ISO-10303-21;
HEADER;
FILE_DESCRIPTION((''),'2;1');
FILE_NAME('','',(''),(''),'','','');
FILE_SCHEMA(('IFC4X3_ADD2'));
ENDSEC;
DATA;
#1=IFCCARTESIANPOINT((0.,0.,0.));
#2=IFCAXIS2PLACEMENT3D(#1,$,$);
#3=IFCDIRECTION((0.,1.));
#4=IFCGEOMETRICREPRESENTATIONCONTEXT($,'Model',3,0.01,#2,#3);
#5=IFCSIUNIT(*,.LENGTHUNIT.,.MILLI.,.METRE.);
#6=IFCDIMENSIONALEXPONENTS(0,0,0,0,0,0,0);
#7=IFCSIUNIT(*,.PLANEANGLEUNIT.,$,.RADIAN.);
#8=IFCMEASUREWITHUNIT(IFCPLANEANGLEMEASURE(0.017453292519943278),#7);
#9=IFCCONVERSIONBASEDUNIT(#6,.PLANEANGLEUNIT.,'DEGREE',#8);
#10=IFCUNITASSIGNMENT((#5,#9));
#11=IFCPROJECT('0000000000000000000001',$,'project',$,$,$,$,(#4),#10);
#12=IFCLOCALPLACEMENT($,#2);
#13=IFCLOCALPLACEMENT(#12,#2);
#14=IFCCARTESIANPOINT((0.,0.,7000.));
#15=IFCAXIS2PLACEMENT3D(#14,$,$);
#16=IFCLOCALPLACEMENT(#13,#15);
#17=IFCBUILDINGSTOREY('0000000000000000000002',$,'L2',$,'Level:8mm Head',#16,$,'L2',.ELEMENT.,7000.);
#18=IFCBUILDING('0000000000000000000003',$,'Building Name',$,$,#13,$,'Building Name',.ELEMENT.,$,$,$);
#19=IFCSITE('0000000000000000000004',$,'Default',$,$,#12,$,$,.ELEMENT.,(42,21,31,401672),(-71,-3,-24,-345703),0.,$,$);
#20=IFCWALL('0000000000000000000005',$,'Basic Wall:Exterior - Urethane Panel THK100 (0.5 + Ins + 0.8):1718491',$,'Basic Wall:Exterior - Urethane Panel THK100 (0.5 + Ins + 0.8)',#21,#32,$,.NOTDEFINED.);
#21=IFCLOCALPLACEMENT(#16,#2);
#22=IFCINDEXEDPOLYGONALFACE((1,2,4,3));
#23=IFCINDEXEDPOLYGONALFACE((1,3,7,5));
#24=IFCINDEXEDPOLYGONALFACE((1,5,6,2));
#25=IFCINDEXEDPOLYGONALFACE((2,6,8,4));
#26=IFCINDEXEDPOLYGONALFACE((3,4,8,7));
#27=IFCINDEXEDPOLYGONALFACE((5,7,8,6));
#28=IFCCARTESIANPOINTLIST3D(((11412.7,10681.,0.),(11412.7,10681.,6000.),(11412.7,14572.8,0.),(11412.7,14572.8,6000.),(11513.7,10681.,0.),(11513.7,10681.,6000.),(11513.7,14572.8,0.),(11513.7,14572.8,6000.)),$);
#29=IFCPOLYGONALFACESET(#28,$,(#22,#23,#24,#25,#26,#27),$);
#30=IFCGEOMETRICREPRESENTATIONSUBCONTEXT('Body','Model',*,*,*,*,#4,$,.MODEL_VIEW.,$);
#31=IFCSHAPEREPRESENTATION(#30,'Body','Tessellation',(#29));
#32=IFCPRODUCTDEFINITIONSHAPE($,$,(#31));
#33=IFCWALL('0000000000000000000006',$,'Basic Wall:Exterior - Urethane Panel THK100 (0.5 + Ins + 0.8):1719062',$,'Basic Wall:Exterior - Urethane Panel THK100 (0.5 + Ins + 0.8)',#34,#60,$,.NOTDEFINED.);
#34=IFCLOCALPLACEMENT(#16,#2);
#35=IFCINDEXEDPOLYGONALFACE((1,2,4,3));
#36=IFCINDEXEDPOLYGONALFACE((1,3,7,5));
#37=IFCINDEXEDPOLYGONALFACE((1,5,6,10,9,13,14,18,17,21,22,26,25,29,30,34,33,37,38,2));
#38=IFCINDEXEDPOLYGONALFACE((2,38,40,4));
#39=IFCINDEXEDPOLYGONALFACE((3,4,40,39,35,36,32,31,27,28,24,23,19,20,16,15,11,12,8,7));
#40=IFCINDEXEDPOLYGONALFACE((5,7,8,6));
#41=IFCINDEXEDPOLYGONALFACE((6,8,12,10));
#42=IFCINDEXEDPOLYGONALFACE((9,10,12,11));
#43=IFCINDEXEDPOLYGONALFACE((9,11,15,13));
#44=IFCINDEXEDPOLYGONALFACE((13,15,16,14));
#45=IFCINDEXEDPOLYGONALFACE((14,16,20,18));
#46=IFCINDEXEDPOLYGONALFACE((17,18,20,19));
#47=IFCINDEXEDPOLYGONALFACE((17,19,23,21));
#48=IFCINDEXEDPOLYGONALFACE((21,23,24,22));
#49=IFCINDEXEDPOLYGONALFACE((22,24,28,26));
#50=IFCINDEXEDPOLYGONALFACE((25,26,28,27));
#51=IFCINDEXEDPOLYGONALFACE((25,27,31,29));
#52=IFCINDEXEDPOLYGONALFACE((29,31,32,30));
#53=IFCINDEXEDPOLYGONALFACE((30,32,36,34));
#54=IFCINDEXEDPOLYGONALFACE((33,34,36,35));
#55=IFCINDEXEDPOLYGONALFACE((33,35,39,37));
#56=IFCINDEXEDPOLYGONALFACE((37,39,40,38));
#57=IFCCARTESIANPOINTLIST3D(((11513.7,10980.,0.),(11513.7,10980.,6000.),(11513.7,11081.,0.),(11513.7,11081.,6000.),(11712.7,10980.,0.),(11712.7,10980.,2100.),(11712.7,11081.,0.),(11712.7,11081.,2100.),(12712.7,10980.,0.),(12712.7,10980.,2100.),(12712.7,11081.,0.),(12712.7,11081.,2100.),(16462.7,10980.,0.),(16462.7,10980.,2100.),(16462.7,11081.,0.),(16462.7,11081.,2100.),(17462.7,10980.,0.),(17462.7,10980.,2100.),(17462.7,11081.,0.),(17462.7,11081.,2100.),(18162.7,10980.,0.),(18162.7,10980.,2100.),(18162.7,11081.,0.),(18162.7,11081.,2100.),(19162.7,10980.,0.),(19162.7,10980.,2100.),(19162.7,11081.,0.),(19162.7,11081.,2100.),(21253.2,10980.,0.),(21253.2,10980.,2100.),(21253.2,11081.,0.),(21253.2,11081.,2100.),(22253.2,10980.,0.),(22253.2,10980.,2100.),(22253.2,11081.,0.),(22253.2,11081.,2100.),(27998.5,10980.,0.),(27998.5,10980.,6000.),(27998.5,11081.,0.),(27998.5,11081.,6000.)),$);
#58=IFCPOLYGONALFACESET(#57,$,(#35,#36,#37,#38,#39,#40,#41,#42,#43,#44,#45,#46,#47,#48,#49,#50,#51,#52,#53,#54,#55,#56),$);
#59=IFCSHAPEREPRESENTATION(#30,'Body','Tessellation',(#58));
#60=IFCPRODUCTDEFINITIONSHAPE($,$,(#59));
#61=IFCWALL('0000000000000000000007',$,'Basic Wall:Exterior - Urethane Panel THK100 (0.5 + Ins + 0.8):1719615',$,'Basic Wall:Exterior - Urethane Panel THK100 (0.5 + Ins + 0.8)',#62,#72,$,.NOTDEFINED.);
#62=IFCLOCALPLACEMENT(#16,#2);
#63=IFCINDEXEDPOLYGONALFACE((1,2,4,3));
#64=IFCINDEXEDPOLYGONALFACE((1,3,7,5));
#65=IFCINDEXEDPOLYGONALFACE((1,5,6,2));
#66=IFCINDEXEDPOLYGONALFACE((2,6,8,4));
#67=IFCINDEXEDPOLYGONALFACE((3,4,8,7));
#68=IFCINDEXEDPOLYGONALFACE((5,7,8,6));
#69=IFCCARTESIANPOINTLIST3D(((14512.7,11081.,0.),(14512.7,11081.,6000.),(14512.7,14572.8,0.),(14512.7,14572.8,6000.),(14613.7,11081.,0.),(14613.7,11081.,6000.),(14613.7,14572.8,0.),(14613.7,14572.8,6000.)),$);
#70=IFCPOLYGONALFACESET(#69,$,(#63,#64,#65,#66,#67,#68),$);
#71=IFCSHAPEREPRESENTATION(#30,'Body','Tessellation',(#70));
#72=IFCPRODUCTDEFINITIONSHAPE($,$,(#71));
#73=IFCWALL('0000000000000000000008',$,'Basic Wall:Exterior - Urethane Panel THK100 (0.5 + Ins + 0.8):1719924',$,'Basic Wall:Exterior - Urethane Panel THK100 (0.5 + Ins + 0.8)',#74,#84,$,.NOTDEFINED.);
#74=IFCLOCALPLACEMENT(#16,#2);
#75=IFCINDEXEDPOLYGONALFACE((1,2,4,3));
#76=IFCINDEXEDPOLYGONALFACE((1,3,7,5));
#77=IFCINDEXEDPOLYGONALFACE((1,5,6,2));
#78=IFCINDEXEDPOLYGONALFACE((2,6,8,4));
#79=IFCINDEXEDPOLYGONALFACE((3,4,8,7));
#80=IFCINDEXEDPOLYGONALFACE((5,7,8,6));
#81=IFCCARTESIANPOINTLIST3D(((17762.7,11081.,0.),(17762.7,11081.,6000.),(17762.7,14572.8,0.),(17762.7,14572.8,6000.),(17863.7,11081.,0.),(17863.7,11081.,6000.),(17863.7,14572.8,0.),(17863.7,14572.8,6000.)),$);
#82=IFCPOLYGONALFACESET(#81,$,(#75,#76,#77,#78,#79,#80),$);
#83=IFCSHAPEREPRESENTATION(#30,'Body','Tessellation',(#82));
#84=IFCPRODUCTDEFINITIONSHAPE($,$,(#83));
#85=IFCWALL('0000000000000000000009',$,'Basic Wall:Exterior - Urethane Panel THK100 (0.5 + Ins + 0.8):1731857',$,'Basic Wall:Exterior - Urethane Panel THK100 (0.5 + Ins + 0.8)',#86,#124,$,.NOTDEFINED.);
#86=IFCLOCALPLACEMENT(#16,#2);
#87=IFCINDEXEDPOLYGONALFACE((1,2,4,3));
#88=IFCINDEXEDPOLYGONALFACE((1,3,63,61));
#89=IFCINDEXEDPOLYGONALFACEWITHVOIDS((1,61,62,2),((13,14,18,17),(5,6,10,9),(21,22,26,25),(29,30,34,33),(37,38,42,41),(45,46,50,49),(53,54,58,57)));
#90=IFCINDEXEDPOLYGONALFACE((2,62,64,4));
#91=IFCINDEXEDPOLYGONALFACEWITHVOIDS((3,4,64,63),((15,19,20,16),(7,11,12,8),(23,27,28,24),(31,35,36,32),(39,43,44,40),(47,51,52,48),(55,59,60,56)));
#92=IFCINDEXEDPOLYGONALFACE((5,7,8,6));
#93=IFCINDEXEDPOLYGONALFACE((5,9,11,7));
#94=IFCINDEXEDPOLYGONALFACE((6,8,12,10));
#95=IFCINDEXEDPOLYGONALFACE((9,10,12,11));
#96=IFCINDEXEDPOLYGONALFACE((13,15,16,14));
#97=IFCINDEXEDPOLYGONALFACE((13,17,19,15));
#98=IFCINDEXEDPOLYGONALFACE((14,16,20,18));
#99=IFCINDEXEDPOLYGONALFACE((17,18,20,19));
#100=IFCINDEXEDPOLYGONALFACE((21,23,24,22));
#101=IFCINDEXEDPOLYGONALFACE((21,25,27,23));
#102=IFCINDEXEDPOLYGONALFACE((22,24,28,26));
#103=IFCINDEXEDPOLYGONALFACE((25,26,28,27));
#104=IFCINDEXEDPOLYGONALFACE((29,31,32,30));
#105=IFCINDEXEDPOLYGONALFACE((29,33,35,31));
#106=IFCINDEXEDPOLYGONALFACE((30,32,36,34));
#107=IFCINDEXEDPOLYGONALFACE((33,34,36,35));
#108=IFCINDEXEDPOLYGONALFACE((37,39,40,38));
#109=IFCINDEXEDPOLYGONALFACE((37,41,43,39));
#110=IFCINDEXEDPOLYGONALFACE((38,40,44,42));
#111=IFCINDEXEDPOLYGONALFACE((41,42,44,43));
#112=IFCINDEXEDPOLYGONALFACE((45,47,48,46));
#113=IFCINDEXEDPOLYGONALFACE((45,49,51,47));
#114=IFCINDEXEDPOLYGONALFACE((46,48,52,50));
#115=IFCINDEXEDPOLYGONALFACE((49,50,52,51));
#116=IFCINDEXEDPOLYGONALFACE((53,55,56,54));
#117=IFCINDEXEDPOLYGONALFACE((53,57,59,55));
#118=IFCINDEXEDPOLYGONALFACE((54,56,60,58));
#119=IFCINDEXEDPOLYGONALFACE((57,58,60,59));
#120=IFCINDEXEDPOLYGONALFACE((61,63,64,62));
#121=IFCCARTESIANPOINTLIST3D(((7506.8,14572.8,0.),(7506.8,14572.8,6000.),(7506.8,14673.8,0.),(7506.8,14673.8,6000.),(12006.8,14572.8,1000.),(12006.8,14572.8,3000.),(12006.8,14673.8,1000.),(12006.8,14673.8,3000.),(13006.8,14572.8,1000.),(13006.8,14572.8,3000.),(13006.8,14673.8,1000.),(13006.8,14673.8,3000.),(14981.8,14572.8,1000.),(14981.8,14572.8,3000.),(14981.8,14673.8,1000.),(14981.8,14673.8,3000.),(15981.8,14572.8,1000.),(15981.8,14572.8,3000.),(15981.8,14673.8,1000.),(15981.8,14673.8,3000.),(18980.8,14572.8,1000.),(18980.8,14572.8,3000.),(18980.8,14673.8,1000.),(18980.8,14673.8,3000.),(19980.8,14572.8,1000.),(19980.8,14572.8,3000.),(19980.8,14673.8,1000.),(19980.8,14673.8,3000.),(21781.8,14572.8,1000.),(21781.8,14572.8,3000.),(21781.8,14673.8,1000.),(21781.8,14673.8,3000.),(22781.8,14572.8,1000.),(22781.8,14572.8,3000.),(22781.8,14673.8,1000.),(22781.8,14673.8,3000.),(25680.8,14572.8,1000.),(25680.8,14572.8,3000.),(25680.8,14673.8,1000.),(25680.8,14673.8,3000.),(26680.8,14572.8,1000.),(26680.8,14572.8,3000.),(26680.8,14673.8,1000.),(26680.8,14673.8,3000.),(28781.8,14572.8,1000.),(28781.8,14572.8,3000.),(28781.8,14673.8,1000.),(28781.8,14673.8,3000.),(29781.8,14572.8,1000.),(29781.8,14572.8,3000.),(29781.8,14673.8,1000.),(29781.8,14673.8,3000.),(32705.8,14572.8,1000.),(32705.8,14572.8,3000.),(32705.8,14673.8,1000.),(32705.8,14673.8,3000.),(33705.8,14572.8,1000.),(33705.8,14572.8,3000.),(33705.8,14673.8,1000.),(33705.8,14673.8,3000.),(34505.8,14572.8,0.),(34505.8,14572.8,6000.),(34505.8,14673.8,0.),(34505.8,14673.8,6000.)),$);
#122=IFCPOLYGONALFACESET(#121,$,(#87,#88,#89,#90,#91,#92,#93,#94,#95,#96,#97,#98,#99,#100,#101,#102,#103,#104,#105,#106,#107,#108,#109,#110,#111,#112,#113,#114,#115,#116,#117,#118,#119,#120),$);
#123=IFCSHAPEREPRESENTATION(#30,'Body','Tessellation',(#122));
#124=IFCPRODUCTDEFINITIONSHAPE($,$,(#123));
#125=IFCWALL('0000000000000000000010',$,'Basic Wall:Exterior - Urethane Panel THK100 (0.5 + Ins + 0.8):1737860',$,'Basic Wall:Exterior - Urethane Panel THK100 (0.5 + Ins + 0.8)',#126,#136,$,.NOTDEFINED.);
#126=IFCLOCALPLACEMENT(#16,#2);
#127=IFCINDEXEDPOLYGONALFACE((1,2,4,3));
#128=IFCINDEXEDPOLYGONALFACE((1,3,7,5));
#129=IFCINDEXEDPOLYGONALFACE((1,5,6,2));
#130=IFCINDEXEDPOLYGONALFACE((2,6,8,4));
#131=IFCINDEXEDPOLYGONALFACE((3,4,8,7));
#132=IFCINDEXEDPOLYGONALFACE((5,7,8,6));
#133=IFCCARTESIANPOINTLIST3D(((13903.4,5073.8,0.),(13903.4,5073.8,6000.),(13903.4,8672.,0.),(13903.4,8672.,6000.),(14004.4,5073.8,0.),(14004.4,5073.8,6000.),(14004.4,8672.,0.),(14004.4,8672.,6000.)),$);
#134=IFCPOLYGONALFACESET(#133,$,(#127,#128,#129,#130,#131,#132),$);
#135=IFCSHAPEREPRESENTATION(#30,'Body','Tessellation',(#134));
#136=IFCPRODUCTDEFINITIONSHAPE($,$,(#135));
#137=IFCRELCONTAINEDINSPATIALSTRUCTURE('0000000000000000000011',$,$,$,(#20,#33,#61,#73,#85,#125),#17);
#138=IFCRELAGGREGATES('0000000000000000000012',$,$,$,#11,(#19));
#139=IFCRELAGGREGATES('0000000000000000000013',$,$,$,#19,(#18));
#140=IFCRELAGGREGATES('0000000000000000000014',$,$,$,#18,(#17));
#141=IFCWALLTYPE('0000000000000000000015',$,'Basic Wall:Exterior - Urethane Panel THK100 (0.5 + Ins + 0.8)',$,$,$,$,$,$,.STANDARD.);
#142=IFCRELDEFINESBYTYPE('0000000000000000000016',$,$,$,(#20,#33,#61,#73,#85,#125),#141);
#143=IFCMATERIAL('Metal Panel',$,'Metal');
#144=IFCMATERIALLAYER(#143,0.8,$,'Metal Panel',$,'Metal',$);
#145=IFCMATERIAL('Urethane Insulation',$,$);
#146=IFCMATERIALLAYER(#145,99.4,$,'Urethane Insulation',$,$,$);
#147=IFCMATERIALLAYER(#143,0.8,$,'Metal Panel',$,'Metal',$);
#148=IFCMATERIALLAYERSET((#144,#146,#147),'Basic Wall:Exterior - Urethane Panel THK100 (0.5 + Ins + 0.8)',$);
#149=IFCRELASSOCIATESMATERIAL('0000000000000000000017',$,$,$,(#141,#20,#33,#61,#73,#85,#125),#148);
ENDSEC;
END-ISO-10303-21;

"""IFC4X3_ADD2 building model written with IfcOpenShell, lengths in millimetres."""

from ifc_helpers import new_model, entity, si_unit, converted_unit, direction, frame, frame_2d, origin, place, context, subcontext, project, spatial, rectangle, extrude, material, layer, layer_set, type_object, element, save


model = new_model("IFC4X3_ADD2")

# Units and contexts
model_context = context("Model", 3, precision=0.01, world=origin(), true_north=direction((0.0, 1.0)))
body_context = subcontext(model_context, "Body", "Model", "MODEL_VIEW")
ifc_project = project(units=[si_unit("LENGTHUNIT", "METRE", prefix="MILLI"), converted_unit("PLANEANGLEUNIT", "DEGREE", entity("IfcPlaneAngleMeasure", 0.017453292519943278), si_unit("PLANEANGLEUNIT", "RADIAN"), dimensions=[0, 0, 0, 0, 0, 0, 0])], contexts=[model_context])

# Site, building, storey
site_placement = place(None, origin())
site = spatial("IfcSite", under=ifc_project, at=site_placement, Name="Default", CompositionType="ELEMENT", RefLatitude=(42, 21, 31, 401672), RefLongitude=(-71, -3, -24, -345703), RefElevation=0.0)
building_placement = place(site_placement, origin())
building = spatial("IfcBuilding", under=site, at=building_placement, Name="Building Name", LongName="Building Name", CompositionType="ELEMENT")
storey_placement = place(building_placement, frame((0.0, 0.0, 7000.0)))
storey = spatial("IfcBuildingStorey", under=building, at=storey_placement, Name="L2", ObjectType="Level:8mm Head", LongName="L2", CompositionType="ELEMENT", Elevation=7000.0)

# Wall
ifc_material_1 = material(Name="Metal Panel", Category="Metal")
ifc_layer_1 = layer(ifc_material_1, 0.8, Name="Metal Panel", Category="Metal")
ifc_material_2 = material(Name="Urethane Insulation")
ifc_layer_2 = layer(ifc_material_2, 99.4, Name="Urethane Insulation")
ifc_layer_3 = layer(ifc_material_1, 0.8, Name="Metal Panel", Category="Metal")
ifc_layer_set = layer_set([ifc_layer_1, ifc_layer_2, ifc_layer_3], Name="Basic Wall:Exterior - Urethane Panel THK100 (0.5 + Ins + 0.8)")
wall_type = type_object("IfcWallType", Name="Basic Wall:Exterior - Urethane Panel THK100 (0.5 + Ins + 0.8)", PredefinedType="STANDARD", material=ifc_layer_set)
wall_1_placement = place(storey_placement, frame((11463.2, 14572.8, 0.0), z_axis=(0.0, 0.0, 1.0), x_axis=(0.0, -1.0, 0.0)))
element("IfcWall", 1, at=wall_1_placement, inside=storey, type_object=wall_type, material=ifc_layer_set, Name="Basic Wall:Exterior - Urethane Panel THK100 (0.5 + Ins + 0.8):1718491", ObjectType="Basic Wall:Exterior - Urethane Panel THK100 (0.5 + Ins + 0.8)", PredefinedType="NOTDEFINED", context=body_context, shape_type="SweptSolid", body=[
    extrude(rectangle(XDim=3891.8, YDim=101.0, at=frame_2d((1945.9, 0.0), x_axis=(-1.0, 0.0))), origin(), (0.0, 0.0, 1.0), 6000.0),
])

# Wall, openings
wall_2_placement = place(storey_placement, frame((11513.7, 11030.5, 0.0)))
wall_2 = element("IfcWall", 2, at=wall_2_placement, inside=storey, type_object=wall_type, material=ifc_layer_set, Name="Basic Wall:Exterior - Urethane Panel THK100 (0.5 + Ins + 0.8):1719062", ObjectType="Basic Wall:Exterior - Urethane Panel THK100 (0.5 + Ins + 0.8)", PredefinedType="NOTDEFINED", context=body_context, shape_type="SweptSolid", body=[
    extrude(rectangle(XDim=16484.9, YDim=101.0, at=frame_2d((8242.4, 0.0), x_axis=(1.0, 0.0))), origin(), (0.0, 0.0, 1.0), 6000.0),
])
opening_1_placement = place(wall_2_placement, frame((9739.6, -50.5, 0.0)))
element("IfcOpeningElement", 3, at=opening_1_placement, cuts=wall_2, PredefinedType="OPENING", context=body_context, shape_type="SweptSolid", body=[
    extrude(rectangle(XDim=2100.0, YDim=1000.0, at=frame_2d((1050.0, 500.0), x_axis=(1.0, 0.0))), frame((0.0, 0.0, 0.0), z_axis=(0.0, 1.0, 0.0), x_axis=(0.0, 0.0, 1.0)), (0.0, 0.0, 1.0), 101.0),
])
opening_2_placement = place(wall_2_placement, frame((199.1, -50.5, 0.0)))
element("IfcOpeningElement", 4, at=opening_2_placement, cuts=wall_2, PredefinedType="OPENING", context=body_context, shape_type="SweptSolid", body=[
    extrude(rectangle(XDim=2100.0, YDim=1000.0, at=frame_2d((1050.0, 500.0), x_axis=(1.0, 0.0))), frame((0.0, 0.0, 0.0), z_axis=(0.0, 1.0, 0.0), x_axis=(0.0, 0.0, 1.0)), (0.0, 0.0, 1.0), 101.0),
])
opening_3_placement = place(wall_2_placement, frame((4949.0, -50.5, 0.0)))
element("IfcOpeningElement", 5, at=opening_3_placement, cuts=wall_2, PredefinedType="OPENING", context=body_context, shape_type="SweptSolid", body=[
    extrude(rectangle(XDim=2100.0, YDim=1000.0, at=frame_2d((1050.0, 500.0), x_axis=(1.0, 0.0))), frame((0.0, 0.0, 0.0), z_axis=(0.0, 1.0, 0.0), x_axis=(0.0, 0.0, 1.0)), (0.0, 0.0, 1.0), 101.0),
])
opening_4_placement = place(wall_2_placement, frame((6649.1, -50.5, 0.0)))
element("IfcOpeningElement", 6, at=opening_4_placement, cuts=wall_2, PredefinedType="OPENING", context=body_context, shape_type="SweptSolid", body=[
    extrude(rectangle(XDim=2100.0, YDim=1000.0, at=frame_2d((1050.0, 500.0), x_axis=(1.0, 0.0))), frame((0.0, 0.0, 0.0), z_axis=(0.0, 1.0, 0.0), x_axis=(0.0, 0.0, 1.0)), (0.0, 0.0, 1.0), 101.0),
])

# Walls
wall_3_placement = place(storey_placement, frame((14563.2, 14572.8, 0.0), z_axis=(0.0, 0.0, 1.0), x_axis=(0.0, -1.0, 0.0)))
element("IfcWall", 7, at=wall_3_placement, inside=storey, type_object=wall_type, material=ifc_layer_set, Name="Basic Wall:Exterior - Urethane Panel THK100 (0.5 + Ins + 0.8):1719615", ObjectType="Basic Wall:Exterior - Urethane Panel THK100 (0.5 + Ins + 0.8)", PredefinedType="NOTDEFINED", context=body_context, shape_type="SweptSolid", body=[
    extrude(rectangle(XDim=3491.8, YDim=101.0, at=frame_2d((1745.9, 0.0), x_axis=(-1.0, 0.0))), origin(), (0.0, 0.0, 1.0), 6000.0),
])
wall_4_placement = place(storey_placement, frame((17813.2, 14572.8, 0.0), z_axis=(0.0, 0.0, 1.0), x_axis=(0.0, -1.0, 0.0)))
element("IfcWall", 8, at=wall_4_placement, inside=storey, type_object=wall_type, material=ifc_layer_set, Name="Basic Wall:Exterior - Urethane Panel THK100 (0.5 + Ins + 0.8):1719924", ObjectType="Basic Wall:Exterior - Urethane Panel THK100 (0.5 + Ins + 0.8)", PredefinedType="NOTDEFINED", context=body_context, shape_type="SweptSolid", body=[
    extrude(rectangle(XDim=3491.8, YDim=101.0, at=frame_2d((1745.9, 0.0), x_axis=(-1.0, 0.0))), origin(), (0.0, 0.0, 1.0), 6000.0),
])

# Wall, openings
wall_5_placement = place(storey_placement, frame((7506.8, 14623.3, 0.0)))
wall_5 = element("IfcWall", 9, at=wall_5_placement, inside=storey, type_object=wall_type, material=ifc_layer_set, Name="Basic Wall:Exterior - Urethane Panel THK100 (0.5 + Ins + 0.8):1731857", ObjectType="Basic Wall:Exterior - Urethane Panel THK100 (0.5 + Ins + 0.8)", PredefinedType="NOTDEFINED", context=body_context, shape_type="SweptSolid", body=[
    extrude(rectangle(XDim=26999.0, YDim=101.0, at=frame_2d((13499.5, 0.0), x_axis=(-1.0, 0.0))), origin(), (0.0, 0.0, 1.0), 6000.0),
])
opening_5_placement = place(wall_5_placement, frame((25199.0, -50.5, 1000.0)))
element("IfcOpeningElement", 10, at=opening_5_placement, cuts=wall_5, PredefinedType="OPENING", context=body_context, shape_type="SweptSolid", body=[
    extrude(rectangle(XDim=2000.0, YDim=1000.0, at=frame_2d((1000.0, 500.0), x_axis=(-1.0, 0.0))), frame((0.0, 0.0, 0.0), z_axis=(0.0, 1.0, 0.0), x_axis=(0.0, 0.0, 1.0)), (0.0, 0.0, 1.0), 101.0),
])
opening_6_placement = place(wall_5_placement, frame((21275.0, -50.5, 1000.0)))
element("IfcOpeningElement", 11, at=opening_6_placement, cuts=wall_5, PredefinedType="OPENING", context=body_context, shape_type="SweptSolid", body=[
    extrude(rectangle(XDim=2000.0, YDim=1000.0, at=frame_2d((1000.0, 500.0), x_axis=(-1.0, 0.0))), frame((0.0, 0.0, 0.0), z_axis=(0.0, 1.0, 0.0), x_axis=(0.0, 0.0, 1.0)), (0.0, 0.0, 1.0), 101.0),
])
opening_7_placement = place(wall_5_placement, frame((18174.0, -50.5, 1000.0)))
element("IfcOpeningElement", 12, at=opening_7_placement, cuts=wall_5, PredefinedType="OPENING", context=body_context, shape_type="SweptSolid", body=[
    extrude(rectangle(XDim=2000.0, YDim=1000.0, at=frame_2d((1000.0, 500.0), x_axis=(-1.0, 0.0))), frame((0.0, 0.0, 0.0), z_axis=(0.0, 1.0, 0.0), x_axis=(0.0, 0.0, 1.0)), (0.0, 0.0, 1.0), 101.0),
])
opening_8_placement = place(wall_5_placement, frame((14275.0, -50.5, 1000.0)))
element("IfcOpeningElement", 13, at=opening_8_placement, cuts=wall_5, PredefinedType="OPENING", context=body_context, shape_type="SweptSolid", body=[
    extrude(rectangle(XDim=2000.0, YDim=1000.0, at=frame_2d((1000.0, 500.0), x_axis=(-1.0, 0.0))), frame((0.0, 0.0, 0.0), z_axis=(0.0, 1.0, 0.0), x_axis=(0.0, 0.0, 1.0)), (0.0, 0.0, 1.0), 101.0),
])
opening_9_placement = place(wall_5_placement, frame((11474.0, -50.5, 1000.0)))
element("IfcOpeningElement", 14, at=opening_9_placement, cuts=wall_5, PredefinedType="OPENING", context=body_context, shape_type="SweptSolid", body=[
    extrude(rectangle(XDim=2000.0, YDim=1000.0, at=frame_2d((1000.0, 500.0), x_axis=(-1.0, 0.0))), frame((0.0, 0.0, 0.0), z_axis=(0.0, 1.0, 0.0), x_axis=(0.0, 0.0, 1.0)), (0.0, 0.0, 1.0), 101.0),
])
opening_10_placement = place(wall_5_placement, frame((7475.0, -50.5, 1000.0)))
element("IfcOpeningElement", 15, at=opening_10_placement, cuts=wall_5, PredefinedType="OPENING", context=body_context, shape_type="SweptSolid", body=[
    extrude(rectangle(XDim=2000.0, YDim=1000.0, at=frame_2d((1000.0, 500.0), x_axis=(-1.0, 0.0))), frame((0.0, 0.0, 0.0), z_axis=(0.0, 1.0, 0.0), x_axis=(0.0, 0.0, 1.0)), (0.0, 0.0, 1.0), 101.0),
])
opening_11_placement = place(wall_5_placement, frame((4500.0, -50.5, 1000.0)))
element("IfcOpeningElement", 16, at=opening_11_placement, cuts=wall_5, PredefinedType="OPENING", context=body_context, shape_type="SweptSolid", body=[
    extrude(rectangle(XDim=2000.0, YDim=1000.0, at=frame_2d((1000.0, 500.0), x_axis=(-1.0, 0.0))), frame((0.0, 0.0, 0.0), z_axis=(0.0, 1.0, 0.0), x_axis=(0.0, 0.0, 1.0)), (0.0, 0.0, 1.0), 101.0),
])

# Wall
wall_6_placement = place(storey_placement, frame((13953.9, 5073.8, 0.0), z_axis=(0.0, 0.0, 1.0), x_axis=(0.0, 1.0, 0.0)))
element("IfcWall", 17, at=wall_6_placement, inside=storey, type_object=wall_type, material=ifc_layer_set, Name="Basic Wall:Exterior - Urethane Panel THK100 (0.5 + Ins + 0.8):1737860", ObjectType="Basic Wall:Exterior - Urethane Panel THK100 (0.5 + Ins + 0.8)", PredefinedType="NOTDEFINED", context=body_context, shape_type="SweptSolid", body=[
    extrude(rectangle(XDim=3598.2, YDim=101.0, at=frame_2d((1799.1, 0.0), x_axis=(-1.0, 0.0))), origin(), (0.0, 0.0, 1.0), 6000.0),
])

save(model, "model.ifc")
